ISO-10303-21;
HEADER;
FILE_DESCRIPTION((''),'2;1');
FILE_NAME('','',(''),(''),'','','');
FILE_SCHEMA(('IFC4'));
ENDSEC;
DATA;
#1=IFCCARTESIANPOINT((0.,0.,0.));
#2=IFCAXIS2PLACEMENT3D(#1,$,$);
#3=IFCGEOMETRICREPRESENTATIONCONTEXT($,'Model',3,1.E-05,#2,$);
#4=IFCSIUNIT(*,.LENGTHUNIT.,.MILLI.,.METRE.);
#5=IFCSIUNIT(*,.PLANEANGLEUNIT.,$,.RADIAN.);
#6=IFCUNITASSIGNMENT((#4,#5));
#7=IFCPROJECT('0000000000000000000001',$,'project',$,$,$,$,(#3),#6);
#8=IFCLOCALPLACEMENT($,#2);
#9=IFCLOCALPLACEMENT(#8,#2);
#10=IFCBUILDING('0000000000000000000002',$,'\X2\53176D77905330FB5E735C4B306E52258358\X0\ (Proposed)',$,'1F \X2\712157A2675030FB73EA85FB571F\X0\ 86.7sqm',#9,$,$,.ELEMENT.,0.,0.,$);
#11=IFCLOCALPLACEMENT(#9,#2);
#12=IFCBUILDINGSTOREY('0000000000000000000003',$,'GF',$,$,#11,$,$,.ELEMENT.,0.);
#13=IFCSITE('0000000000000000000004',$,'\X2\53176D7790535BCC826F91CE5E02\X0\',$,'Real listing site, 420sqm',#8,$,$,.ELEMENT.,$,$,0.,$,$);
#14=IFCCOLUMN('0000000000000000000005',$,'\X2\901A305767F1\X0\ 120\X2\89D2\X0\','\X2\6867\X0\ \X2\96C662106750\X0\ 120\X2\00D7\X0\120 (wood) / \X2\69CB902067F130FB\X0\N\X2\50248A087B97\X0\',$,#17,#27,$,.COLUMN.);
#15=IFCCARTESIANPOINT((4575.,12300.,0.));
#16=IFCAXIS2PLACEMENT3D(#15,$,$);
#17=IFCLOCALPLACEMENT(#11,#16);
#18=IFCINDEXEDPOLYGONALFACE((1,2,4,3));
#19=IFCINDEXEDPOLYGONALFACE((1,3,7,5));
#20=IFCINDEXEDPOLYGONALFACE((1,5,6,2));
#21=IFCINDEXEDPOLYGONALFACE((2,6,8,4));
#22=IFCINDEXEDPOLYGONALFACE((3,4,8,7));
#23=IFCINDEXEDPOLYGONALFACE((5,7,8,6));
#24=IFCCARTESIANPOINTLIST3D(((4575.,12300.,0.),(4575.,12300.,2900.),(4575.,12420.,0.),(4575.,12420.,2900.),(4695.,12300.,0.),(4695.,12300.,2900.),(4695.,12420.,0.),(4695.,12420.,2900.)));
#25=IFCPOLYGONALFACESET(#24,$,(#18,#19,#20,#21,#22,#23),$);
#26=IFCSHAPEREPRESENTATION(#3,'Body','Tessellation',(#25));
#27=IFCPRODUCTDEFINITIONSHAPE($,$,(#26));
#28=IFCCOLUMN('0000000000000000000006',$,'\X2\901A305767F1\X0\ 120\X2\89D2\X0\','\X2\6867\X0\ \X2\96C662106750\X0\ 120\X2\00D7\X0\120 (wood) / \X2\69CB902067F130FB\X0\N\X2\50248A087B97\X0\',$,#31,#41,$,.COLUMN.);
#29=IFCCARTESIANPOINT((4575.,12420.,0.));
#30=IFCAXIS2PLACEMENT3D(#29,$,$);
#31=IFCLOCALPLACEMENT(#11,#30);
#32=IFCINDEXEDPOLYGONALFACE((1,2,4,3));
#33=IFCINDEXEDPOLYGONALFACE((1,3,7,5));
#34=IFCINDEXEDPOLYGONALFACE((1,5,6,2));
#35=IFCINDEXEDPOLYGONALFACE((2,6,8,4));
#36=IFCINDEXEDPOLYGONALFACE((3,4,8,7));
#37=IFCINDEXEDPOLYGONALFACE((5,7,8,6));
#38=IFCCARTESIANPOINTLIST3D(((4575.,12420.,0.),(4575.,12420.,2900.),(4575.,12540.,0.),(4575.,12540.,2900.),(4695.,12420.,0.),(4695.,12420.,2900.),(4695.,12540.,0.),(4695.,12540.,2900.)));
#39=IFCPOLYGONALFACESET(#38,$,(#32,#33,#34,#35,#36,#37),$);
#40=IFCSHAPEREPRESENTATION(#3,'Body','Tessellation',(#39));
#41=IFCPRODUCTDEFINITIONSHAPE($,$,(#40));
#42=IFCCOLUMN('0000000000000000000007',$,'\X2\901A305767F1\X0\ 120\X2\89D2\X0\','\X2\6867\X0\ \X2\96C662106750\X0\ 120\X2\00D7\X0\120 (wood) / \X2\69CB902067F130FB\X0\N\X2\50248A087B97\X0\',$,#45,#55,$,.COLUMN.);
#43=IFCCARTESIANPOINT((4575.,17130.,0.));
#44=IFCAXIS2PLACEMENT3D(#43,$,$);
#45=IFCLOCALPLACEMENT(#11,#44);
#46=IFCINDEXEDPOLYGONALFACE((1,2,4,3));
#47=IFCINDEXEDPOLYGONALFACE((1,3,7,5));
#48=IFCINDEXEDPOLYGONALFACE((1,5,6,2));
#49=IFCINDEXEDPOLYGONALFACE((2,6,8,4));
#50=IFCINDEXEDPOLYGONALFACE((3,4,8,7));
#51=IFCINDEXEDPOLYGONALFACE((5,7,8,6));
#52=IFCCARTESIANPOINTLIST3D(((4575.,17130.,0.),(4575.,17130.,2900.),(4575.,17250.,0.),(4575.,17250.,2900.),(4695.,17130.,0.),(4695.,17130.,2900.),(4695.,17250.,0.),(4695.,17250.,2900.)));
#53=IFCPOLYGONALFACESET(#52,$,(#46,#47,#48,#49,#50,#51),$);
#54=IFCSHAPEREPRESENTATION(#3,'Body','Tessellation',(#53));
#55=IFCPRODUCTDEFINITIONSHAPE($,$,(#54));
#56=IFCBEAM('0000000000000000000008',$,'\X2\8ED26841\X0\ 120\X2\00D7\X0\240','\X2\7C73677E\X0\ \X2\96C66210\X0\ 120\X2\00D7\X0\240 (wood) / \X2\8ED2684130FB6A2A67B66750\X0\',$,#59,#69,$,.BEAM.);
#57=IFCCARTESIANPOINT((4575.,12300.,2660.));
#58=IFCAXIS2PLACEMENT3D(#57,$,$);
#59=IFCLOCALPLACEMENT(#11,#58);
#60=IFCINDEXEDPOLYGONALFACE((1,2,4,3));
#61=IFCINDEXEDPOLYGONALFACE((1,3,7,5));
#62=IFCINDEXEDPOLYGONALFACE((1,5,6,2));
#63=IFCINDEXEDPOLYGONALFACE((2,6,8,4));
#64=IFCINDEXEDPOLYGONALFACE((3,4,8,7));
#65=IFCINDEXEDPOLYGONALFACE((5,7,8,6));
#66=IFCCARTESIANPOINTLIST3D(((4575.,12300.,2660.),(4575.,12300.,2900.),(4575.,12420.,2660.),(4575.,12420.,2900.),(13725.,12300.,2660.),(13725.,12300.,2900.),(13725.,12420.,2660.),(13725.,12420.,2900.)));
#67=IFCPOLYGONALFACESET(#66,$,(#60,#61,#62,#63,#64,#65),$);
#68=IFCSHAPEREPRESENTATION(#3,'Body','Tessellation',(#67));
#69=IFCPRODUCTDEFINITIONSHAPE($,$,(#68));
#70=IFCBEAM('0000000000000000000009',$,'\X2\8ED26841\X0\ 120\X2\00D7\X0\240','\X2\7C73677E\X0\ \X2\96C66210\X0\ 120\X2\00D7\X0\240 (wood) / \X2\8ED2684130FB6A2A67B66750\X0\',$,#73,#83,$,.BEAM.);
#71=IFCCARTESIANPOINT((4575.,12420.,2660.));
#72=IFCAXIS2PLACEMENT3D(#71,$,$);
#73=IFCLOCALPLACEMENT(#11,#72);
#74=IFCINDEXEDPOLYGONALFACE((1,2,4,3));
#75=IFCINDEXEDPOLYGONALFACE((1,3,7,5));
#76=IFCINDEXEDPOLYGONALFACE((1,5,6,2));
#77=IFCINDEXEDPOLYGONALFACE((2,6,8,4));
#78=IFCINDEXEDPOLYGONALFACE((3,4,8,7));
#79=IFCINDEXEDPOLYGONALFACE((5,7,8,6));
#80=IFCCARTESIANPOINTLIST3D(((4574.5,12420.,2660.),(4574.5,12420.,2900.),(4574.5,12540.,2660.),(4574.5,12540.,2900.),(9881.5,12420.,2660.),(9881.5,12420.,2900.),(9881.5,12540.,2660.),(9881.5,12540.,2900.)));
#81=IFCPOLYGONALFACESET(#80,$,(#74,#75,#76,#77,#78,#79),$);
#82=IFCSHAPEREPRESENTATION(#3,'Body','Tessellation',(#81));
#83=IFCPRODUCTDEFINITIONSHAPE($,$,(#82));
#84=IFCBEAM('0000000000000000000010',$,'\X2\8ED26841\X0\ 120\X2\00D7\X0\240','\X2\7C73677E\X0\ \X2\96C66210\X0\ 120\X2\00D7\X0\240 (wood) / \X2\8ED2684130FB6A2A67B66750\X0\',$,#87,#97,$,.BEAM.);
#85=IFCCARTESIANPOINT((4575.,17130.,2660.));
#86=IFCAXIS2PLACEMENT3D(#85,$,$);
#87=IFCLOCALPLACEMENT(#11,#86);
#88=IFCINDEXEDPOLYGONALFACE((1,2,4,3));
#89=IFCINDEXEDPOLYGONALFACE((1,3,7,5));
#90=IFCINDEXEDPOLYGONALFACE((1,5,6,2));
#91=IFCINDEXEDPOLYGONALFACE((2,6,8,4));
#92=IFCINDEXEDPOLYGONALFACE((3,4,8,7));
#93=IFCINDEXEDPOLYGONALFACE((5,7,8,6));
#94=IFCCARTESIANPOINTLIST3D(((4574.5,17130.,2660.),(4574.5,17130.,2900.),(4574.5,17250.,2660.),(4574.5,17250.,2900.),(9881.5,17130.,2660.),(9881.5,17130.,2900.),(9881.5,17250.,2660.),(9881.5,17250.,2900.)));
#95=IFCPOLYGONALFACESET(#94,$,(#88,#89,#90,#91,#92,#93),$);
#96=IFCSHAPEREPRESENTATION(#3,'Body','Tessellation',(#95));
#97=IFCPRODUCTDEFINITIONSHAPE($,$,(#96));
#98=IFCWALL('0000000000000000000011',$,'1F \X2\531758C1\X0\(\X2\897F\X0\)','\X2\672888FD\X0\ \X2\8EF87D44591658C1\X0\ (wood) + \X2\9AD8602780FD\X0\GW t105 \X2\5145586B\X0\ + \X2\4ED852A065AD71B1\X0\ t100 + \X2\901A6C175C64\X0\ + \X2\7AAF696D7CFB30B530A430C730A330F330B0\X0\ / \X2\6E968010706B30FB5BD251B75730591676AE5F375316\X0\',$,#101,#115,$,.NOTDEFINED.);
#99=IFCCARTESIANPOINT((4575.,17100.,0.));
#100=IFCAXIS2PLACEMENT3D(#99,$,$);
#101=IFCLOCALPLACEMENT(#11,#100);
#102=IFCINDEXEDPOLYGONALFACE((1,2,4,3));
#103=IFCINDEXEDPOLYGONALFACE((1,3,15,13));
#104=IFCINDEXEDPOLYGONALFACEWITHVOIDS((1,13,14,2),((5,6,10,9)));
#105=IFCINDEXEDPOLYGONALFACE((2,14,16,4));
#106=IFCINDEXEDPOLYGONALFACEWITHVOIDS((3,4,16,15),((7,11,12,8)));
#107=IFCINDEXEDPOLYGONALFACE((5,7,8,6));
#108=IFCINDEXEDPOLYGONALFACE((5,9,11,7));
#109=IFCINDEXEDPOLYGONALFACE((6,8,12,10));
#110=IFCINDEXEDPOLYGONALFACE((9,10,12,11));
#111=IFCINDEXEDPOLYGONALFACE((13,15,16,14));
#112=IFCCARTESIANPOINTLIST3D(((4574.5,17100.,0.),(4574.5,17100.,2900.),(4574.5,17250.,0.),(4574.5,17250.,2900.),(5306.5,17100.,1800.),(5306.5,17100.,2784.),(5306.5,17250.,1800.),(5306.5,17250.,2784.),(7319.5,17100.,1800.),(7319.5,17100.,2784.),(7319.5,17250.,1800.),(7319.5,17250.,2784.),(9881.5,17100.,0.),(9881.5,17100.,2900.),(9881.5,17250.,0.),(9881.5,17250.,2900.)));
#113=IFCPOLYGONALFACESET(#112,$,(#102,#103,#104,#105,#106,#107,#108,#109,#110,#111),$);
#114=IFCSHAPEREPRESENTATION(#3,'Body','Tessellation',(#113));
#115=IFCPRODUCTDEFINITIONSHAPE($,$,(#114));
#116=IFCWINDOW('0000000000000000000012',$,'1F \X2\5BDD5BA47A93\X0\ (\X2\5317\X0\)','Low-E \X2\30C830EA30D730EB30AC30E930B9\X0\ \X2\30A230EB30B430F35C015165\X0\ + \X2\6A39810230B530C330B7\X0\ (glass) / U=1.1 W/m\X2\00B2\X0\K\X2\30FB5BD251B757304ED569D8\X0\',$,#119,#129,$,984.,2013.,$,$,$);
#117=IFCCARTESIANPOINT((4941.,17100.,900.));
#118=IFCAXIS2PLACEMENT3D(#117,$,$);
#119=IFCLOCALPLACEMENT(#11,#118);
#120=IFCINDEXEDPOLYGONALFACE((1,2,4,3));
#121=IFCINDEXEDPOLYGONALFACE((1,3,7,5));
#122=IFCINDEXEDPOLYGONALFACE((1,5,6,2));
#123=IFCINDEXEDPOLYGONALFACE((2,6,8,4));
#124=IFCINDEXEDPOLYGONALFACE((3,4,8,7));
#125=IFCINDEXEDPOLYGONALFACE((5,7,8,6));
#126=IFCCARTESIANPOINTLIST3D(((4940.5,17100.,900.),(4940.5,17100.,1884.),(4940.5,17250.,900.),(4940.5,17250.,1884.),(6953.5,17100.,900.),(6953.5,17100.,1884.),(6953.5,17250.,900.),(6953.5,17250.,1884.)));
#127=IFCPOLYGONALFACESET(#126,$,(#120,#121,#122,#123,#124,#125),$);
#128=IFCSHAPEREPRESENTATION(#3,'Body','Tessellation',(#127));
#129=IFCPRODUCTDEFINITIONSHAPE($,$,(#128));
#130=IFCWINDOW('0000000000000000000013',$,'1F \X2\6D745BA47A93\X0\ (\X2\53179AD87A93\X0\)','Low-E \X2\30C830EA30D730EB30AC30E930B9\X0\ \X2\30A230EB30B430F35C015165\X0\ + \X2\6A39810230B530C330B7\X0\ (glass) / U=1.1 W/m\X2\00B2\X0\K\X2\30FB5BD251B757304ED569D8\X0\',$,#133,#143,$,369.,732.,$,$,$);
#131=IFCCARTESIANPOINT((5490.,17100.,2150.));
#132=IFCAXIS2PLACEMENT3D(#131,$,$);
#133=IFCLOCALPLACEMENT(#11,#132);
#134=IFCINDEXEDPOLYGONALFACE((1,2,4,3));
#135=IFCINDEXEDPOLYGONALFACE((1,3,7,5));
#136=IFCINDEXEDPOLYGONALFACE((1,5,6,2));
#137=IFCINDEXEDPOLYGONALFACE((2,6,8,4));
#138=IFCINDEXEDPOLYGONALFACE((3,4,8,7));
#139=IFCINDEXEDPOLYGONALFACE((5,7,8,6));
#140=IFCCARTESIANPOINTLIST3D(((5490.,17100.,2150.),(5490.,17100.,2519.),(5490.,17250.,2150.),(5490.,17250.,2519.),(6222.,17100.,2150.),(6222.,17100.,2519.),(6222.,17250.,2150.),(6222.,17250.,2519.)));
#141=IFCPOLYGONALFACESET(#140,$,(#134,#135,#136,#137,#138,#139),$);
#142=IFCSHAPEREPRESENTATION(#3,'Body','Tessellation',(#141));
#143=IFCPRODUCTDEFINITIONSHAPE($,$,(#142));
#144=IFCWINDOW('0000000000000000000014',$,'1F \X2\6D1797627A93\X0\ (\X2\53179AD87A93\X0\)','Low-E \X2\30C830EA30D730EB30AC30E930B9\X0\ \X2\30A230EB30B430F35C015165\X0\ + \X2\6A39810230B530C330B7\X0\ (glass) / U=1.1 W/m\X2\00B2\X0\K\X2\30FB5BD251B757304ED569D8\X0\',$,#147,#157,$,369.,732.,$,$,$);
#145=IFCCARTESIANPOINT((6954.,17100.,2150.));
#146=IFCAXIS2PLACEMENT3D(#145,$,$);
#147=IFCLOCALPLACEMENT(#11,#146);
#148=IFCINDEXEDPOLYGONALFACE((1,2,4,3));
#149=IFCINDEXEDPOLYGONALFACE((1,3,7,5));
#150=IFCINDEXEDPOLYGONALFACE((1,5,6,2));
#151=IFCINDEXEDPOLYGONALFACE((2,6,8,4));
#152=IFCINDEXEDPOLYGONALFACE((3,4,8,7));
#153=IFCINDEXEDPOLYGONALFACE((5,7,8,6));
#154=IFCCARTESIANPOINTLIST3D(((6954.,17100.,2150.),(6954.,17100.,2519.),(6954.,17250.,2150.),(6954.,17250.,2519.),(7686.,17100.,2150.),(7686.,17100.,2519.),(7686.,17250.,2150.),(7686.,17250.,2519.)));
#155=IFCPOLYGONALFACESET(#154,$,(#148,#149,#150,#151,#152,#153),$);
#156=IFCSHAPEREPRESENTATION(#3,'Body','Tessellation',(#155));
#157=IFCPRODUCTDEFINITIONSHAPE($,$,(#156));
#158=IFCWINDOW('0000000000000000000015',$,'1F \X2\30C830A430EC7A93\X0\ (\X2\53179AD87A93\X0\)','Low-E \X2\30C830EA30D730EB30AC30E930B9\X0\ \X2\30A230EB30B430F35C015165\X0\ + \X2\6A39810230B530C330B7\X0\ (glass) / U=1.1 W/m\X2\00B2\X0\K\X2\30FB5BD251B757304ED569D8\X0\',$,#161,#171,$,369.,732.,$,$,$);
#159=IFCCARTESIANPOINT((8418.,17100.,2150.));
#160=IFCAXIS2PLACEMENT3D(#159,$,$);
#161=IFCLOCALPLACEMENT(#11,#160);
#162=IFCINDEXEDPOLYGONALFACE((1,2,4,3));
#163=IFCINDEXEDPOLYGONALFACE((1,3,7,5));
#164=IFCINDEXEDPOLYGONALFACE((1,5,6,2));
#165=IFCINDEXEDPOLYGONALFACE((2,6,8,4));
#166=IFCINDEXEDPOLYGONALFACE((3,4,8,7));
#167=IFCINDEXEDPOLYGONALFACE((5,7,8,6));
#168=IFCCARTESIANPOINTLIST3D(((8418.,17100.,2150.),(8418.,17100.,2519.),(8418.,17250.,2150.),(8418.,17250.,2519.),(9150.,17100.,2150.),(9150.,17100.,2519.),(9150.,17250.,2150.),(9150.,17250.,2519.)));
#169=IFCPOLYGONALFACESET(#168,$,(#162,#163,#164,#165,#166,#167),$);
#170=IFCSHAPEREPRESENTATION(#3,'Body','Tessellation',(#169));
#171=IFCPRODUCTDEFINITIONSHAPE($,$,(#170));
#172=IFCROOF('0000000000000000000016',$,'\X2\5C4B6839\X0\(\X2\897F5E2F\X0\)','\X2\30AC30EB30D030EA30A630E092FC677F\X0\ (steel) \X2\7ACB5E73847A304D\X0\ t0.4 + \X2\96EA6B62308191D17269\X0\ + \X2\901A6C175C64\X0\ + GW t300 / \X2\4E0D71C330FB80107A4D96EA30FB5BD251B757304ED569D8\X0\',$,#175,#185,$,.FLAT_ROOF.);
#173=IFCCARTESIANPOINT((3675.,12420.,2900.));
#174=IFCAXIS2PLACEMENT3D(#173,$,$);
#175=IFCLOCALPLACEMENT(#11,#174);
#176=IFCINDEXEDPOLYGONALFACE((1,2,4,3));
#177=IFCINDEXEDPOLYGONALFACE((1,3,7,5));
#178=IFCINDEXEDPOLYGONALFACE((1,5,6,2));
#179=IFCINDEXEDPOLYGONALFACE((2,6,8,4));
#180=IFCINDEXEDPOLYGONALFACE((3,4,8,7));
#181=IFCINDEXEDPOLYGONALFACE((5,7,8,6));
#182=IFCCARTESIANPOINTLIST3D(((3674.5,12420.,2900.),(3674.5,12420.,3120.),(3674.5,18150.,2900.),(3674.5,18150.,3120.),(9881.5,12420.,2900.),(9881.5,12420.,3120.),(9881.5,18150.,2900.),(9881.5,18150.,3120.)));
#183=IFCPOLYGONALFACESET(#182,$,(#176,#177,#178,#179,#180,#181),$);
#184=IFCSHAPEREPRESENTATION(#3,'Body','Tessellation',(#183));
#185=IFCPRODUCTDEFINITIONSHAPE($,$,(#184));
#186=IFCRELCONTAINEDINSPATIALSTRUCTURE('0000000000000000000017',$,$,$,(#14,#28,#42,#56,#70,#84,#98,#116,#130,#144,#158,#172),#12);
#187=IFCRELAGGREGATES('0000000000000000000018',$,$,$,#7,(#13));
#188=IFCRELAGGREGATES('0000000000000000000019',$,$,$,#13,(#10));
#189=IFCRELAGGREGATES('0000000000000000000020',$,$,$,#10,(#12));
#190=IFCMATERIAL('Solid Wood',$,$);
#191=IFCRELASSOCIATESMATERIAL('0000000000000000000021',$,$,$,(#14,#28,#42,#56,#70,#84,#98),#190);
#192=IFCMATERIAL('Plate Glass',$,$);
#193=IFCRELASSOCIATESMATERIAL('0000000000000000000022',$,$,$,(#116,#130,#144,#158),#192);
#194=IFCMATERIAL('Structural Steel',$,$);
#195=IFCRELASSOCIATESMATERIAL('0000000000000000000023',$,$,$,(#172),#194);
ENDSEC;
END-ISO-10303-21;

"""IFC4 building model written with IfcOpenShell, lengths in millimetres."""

from ifc_helpers import new_model, si_unit, frame, frame_2d, origin, place, context, project, spatial, rectangle, extrude, material, element, fill, save


model = new_model("IFC4")

# Units and contexts
model_context = context("Model", 3, precision=1e-05, world=origin())
ifc_project = project(units=[si_unit("LENGTHUNIT", "METRE", prefix="MILLI"), si_unit("PLANEANGLEUNIT", "RADIAN")], contexts=[model_context])

# Site, building, storey
site_placement = place(None, origin())
site = spatial("IfcSite", under=ifc_project, at=site_placement, Name="北海道富良野市", ObjectType="Real listing site, 420sqm", CompositionType="ELEMENT", RefElevation=0.0)
building_placement = place(site_placement, origin())
building = spatial("IfcBuilding", under=site, at=building_placement, Name="北海道・平屋の別荘 (Proposed)", ObjectType="1F 無垢材・珪藻土 86.7sqm", CompositionType="ELEMENT", ElevationOfRefHeight=0.0, ElevationOfTerrain=0.0)
storey_placement = place(building_placement, origin())
storey = spatial("IfcBuildingStorey", under=building, at=storey_placement, Name="GF", CompositionType="ELEMENT", Elevation=0.0)

# Columns
ifc_material_1 = material(Name="Solid Wood")
column_1_placement = place(storey_placement, frame((4575.0, 12300.0, 0.0)))
element("IfcColumn", 1, at=column_1_placement, inside=storey, material=ifc_material_1, Name="通し柱 120角", Description="桧 集成材 120×120 (wood) / 構造柱・N値計算", PredefinedType="COLUMN", context=model_context, shape_type="SweptSolid", body=[
    extrude(rectangle(XDim=120.0, YDim=120.0, at=frame_2d((60.0, 60.0))), frame((4575.0, 12300.0, 0.0)), (0.0, 0.0, 1.0), 2900.0),
])
column_2_placement = place(storey_placement, frame((4575.0, 12420.0, 0.0)))
element("IfcColumn", 2, at=column_2_placement, inside=storey, material=ifc_material_1, Name="通し柱 120角", Description="桧 集成材 120×120 (wood) / 構造柱・N値計算", PredefinedType="COLUMN", context=model_context, shape_type="SweptSolid", body=[
    extrude(rectangle(XDim=120.0, YDim=120.0, at=frame_2d((60.0, 60.0))), frame((4575.0, 12420.0, 0.0)), (0.0, 0.0, 1.0), 2900.0),
])
column_3_placement = place(storey_placement, frame((4575.0, 17130.0, 0.0)))
element("IfcColumn", 3, at=column_3_placement, inside=storey, material=ifc_material_1, Name="通し柱 120角", Description="桧 集成材 120×120 (wood) / 構造柱・N値計算", PredefinedType="COLUMN", context=model_context, shape_type="SweptSolid", body=[
    extrude(rectangle(XDim=120.0, YDim=120.0, at=frame_2d((60.0, 60.0))), frame((4575.0, 17130.0, 0.0)), (0.0, 0.0, 1.0), 2900.0),
])

# Beams
beam_1_placement = place(storey_placement, frame((4575.0, 12300.0, 2660.0)))
element("IfcBeam", 4, at=beam_1_placement, inside=storey, material=ifc_material_1, Name="軒桁 120×240", Description="米松 集成 120×240 (wood) / 軒桁・横架材", PredefinedType="BEAM", context=model_context, shape_type="SweptSolid", body=[
    extrude(rectangle(XDim=9150.0, YDim=120.0, at=frame_2d((4575.0, 60.0))), frame((4575.0, 12300.0, 2660.0)), (0.0, 0.0, 1.0), 240.0),
])
beam_2_placement = place(storey_placement, frame((4575.0, 12420.0, 2660.0)))
element("IfcBeam", 5, at=beam_2_placement, inside=storey, material=ifc_material_1, Name="軒桁 120×240", Description="米松 集成 120×240 (wood) / 軒桁・横架材", PredefinedType="BEAM", context=model_context, shape_type="SweptSolid", body=[
    extrude(rectangle(XDim=5307.0, YDim=120.0, at=frame_2d((2653.0, 60.0))), frame((4575.0, 12420.0, 2660.0)), (0.0, 0.0, 1.0), 240.0),
])
beam_3_placement = place(storey_placement, frame((4575.0, 17130.0, 2660.0)))
element("IfcBeam", 6, at=beam_3_placement, inside=storey, material=ifc_material_1, Name="軒桁 120×240", Description="米松 集成 120×240 (wood) / 軒桁・横架材", PredefinedType="BEAM", context=model_context, shape_type="SweptSolid", body=[
    extrude(rectangle(XDim=5307.0, YDim=120.0, at=frame_2d((2653.0, 60.0))), frame((4575.0, 17130.0, 2660.0)), (0.0, 0.0, 1.0), 240.0),
])

# Wall, openings, windows
wall_1_placement = place(storey_placement, frame((4575.0, 17100.0, 0.0)))
wall_1 = element("IfcWall", 7, at=wall_1_placement, inside=storey, material=ifc_material_1, Name="1F 北壁(西)", Description="木製 軸組外壁 (wood) + 高性能GW t105 充填 + 付加断熱 t100 + 通気層 + 窯業系サイディング / 準耐火・寒冷地外皮強化", PredefinedType="NOTDEFINED", context=model_context, shape_type="SweptSolid", body=[
    extrude(rectangle(XDim=5307.0, YDim=150.0, at=frame_2d((2653.0, 75.0))), frame((4575.0, 17100.0, 0.0)), (0.0, 0.0, 1.0), 2900.0),
])
opening_1_placement = place(storey_placement, frame((4941.0, 17100.0, 900.0)))
opening_1 = element("IfcOpeningElement", 8, at=opening_1_placement, cuts=wall_1, PredefinedType="NOTDEFINED", context=model_context, shape_type="SweptSolid", body=[
    extrude(rectangle(XDim=2013.0, YDim=150.0, at=frame_2d((1006.0, 75.0))), frame((4941.0, 17100.0, 900.0)), (0.0, 0.0, 1.0), 984.0),
])
opening_2_placement = place(storey_placement, frame((5490.0, 17100.0, 2150.0)))
opening_2 = element("IfcOpeningElement", 9, at=opening_2_placement, cuts=wall_1, PredefinedType="NOTDEFINED", context=model_context, shape_type="SweptSolid", body=[
    extrude(rectangle(XDim=732.0, YDim=150.0, at=frame_2d((366.0, 75.0))), frame((5490.0, 17100.0, 2150.0)), (0.0, 0.0, 1.0), 369.0),
])
opening_3_placement = place(storey_placement, frame((6954.0, 17100.0, 2150.0)))
opening_3 = element("IfcOpeningElement", 10, at=opening_3_placement, cuts=wall_1, PredefinedType="NOTDEFINED", context=model_context, shape_type="SweptSolid", body=[
    extrude(rectangle(XDim=732.0, YDim=150.0, at=frame_2d((366.0, 75.0))), frame((6954.0, 17100.0, 2150.0)), (0.0, 0.0, 1.0), 369.0),
])
opening_4_placement = place(storey_placement, frame((8418.0, 17100.0, 2150.0)))
opening_4 = element("IfcOpeningElement", 11, at=opening_4_placement, cuts=wall_1, PredefinedType="NOTDEFINED", context=model_context, shape_type="SweptSolid", body=[
    extrude(rectangle(XDim=732.0, YDim=150.0, at=frame_2d((366.0, 75.0))), frame((8418.0, 17100.0, 2150.0)), (0.0, 0.0, 1.0), 369.0),
])
ifc_material_2 = material(Name="Plate Glass")
window_1_placement = place(storey_placement, frame((4941.0, 17100.0, 900.0)))
window_1 = element("IfcWindow", 12, at=window_1_placement, inside=storey, material=ifc_material_2, Name="1F 寝室窓 (北)", Description="Low-E トリプルガラス アルゴン封入 + 樹脂サッシ (glass) / U=1.1 W/m²K・寒冷地仕様", OverallHeight=984.0, OverallWidth=2013.0, context=model_context, shape_type="SweptSolid", body=[
    extrude(rectangle(XDim=2013.0, YDim=150.0, at=frame_2d((1006.0, 75.0))), frame((4941.0, 17100.0, 900.0)), (0.0, 0.0, 1.0), 984.0),
])
fill(opening_1, window_1)
window_2_placement = place(storey_placement, frame((5490.0, 17100.0, 2150.0)))
window_2 = element("IfcWindow", 13, at=window_2_placement, inside=storey, material=ifc_material_2, Name="1F 浴室窓 (北高窓)", Description="Low-E トリプルガラス アルゴン封入 + 樹脂サッシ (glass) / U=1.1 W/m²K・寒冷地仕様", OverallHeight=369.0, OverallWidth=732.0, context=model_context, shape_type="SweptSolid", body=[
    extrude(rectangle(XDim=732.0, YDim=150.0, at=frame_2d((366.0, 75.0))), frame((5490.0, 17100.0, 2150.0)), (0.0, 0.0, 1.0), 369.0),
])
fill(opening_2, window_2)
window_3_placement = place(storey_placement, frame((6954.0, 17100.0, 2150.0)))
window_3 = element("IfcWindow", 14, at=window_3_placement, inside=storey, material=ifc_material_2, Name="1F 洗面窓 (北高窓)", Description="Low-E トリプルガラス アルゴン封入 + 樹脂サッシ (glass) / U=1.1 W/m²K・寒冷地仕様", OverallHeight=369.0, OverallWidth=732.0, context=model_context, shape_type="SweptSolid", body=[
    extrude(rectangle(XDim=732.0, YDim=150.0, at=frame_2d((366.0, 75.0))), frame((6954.0, 17100.0, 2150.0)), (0.0, 0.0, 1.0), 369.0),
])
fill(opening_3, window_3)
window_4_placement = place(storey_placement, frame((8418.0, 17100.0, 2150.0)))
window_4 = element("IfcWindow", 15, at=window_4_placement, inside=storey, material=ifc_material_2, Name="1F トイレ窓 (北高窓)", Description="Low-E トリプルガラス アルゴン封入 + 樹脂サッシ (glass) / U=1.1 W/m²K・寒冷地仕様", OverallHeight=369.0, OverallWidth=732.0, context=model_context, shape_type="SweptSolid", body=[
    extrude(rectangle(XDim=732.0, YDim=150.0, at=frame_2d((366.0, 75.0))), frame((8418.0, 17100.0, 2150.0)), (0.0, 0.0, 1.0), 369.0),
])
fill(opening_4, window_4)

# Roof
ifc_material_3 = material(Name="Structural Steel")
roof_placement = place(storey_placement, frame((3675.0, 12420.0, 2900.0)))
element("IfcRoof", 16, at=roof_placement, inside=storey, material=ifc_material_3, Name="屋根(西帯)", Description="ガルバリウム鋼板 (steel) 立平葺き t0.4 + 雪止め金物 + 通気層 + GW t300 / 不燃・耐積雪・寒冷地仕様", PredefinedType="FLAT_ROOF", context=model_context, shape_type="SweptSolid", body=[
    extrude(rectangle(XDim=6207.0, YDim=5730.0, at=frame_2d((3103.0, 2865.0))), frame((3675.0, 12420.0, 2900.0)), (0.0, 0.0, 1.0), 220.0),
])

save(model, "model.ifc")
